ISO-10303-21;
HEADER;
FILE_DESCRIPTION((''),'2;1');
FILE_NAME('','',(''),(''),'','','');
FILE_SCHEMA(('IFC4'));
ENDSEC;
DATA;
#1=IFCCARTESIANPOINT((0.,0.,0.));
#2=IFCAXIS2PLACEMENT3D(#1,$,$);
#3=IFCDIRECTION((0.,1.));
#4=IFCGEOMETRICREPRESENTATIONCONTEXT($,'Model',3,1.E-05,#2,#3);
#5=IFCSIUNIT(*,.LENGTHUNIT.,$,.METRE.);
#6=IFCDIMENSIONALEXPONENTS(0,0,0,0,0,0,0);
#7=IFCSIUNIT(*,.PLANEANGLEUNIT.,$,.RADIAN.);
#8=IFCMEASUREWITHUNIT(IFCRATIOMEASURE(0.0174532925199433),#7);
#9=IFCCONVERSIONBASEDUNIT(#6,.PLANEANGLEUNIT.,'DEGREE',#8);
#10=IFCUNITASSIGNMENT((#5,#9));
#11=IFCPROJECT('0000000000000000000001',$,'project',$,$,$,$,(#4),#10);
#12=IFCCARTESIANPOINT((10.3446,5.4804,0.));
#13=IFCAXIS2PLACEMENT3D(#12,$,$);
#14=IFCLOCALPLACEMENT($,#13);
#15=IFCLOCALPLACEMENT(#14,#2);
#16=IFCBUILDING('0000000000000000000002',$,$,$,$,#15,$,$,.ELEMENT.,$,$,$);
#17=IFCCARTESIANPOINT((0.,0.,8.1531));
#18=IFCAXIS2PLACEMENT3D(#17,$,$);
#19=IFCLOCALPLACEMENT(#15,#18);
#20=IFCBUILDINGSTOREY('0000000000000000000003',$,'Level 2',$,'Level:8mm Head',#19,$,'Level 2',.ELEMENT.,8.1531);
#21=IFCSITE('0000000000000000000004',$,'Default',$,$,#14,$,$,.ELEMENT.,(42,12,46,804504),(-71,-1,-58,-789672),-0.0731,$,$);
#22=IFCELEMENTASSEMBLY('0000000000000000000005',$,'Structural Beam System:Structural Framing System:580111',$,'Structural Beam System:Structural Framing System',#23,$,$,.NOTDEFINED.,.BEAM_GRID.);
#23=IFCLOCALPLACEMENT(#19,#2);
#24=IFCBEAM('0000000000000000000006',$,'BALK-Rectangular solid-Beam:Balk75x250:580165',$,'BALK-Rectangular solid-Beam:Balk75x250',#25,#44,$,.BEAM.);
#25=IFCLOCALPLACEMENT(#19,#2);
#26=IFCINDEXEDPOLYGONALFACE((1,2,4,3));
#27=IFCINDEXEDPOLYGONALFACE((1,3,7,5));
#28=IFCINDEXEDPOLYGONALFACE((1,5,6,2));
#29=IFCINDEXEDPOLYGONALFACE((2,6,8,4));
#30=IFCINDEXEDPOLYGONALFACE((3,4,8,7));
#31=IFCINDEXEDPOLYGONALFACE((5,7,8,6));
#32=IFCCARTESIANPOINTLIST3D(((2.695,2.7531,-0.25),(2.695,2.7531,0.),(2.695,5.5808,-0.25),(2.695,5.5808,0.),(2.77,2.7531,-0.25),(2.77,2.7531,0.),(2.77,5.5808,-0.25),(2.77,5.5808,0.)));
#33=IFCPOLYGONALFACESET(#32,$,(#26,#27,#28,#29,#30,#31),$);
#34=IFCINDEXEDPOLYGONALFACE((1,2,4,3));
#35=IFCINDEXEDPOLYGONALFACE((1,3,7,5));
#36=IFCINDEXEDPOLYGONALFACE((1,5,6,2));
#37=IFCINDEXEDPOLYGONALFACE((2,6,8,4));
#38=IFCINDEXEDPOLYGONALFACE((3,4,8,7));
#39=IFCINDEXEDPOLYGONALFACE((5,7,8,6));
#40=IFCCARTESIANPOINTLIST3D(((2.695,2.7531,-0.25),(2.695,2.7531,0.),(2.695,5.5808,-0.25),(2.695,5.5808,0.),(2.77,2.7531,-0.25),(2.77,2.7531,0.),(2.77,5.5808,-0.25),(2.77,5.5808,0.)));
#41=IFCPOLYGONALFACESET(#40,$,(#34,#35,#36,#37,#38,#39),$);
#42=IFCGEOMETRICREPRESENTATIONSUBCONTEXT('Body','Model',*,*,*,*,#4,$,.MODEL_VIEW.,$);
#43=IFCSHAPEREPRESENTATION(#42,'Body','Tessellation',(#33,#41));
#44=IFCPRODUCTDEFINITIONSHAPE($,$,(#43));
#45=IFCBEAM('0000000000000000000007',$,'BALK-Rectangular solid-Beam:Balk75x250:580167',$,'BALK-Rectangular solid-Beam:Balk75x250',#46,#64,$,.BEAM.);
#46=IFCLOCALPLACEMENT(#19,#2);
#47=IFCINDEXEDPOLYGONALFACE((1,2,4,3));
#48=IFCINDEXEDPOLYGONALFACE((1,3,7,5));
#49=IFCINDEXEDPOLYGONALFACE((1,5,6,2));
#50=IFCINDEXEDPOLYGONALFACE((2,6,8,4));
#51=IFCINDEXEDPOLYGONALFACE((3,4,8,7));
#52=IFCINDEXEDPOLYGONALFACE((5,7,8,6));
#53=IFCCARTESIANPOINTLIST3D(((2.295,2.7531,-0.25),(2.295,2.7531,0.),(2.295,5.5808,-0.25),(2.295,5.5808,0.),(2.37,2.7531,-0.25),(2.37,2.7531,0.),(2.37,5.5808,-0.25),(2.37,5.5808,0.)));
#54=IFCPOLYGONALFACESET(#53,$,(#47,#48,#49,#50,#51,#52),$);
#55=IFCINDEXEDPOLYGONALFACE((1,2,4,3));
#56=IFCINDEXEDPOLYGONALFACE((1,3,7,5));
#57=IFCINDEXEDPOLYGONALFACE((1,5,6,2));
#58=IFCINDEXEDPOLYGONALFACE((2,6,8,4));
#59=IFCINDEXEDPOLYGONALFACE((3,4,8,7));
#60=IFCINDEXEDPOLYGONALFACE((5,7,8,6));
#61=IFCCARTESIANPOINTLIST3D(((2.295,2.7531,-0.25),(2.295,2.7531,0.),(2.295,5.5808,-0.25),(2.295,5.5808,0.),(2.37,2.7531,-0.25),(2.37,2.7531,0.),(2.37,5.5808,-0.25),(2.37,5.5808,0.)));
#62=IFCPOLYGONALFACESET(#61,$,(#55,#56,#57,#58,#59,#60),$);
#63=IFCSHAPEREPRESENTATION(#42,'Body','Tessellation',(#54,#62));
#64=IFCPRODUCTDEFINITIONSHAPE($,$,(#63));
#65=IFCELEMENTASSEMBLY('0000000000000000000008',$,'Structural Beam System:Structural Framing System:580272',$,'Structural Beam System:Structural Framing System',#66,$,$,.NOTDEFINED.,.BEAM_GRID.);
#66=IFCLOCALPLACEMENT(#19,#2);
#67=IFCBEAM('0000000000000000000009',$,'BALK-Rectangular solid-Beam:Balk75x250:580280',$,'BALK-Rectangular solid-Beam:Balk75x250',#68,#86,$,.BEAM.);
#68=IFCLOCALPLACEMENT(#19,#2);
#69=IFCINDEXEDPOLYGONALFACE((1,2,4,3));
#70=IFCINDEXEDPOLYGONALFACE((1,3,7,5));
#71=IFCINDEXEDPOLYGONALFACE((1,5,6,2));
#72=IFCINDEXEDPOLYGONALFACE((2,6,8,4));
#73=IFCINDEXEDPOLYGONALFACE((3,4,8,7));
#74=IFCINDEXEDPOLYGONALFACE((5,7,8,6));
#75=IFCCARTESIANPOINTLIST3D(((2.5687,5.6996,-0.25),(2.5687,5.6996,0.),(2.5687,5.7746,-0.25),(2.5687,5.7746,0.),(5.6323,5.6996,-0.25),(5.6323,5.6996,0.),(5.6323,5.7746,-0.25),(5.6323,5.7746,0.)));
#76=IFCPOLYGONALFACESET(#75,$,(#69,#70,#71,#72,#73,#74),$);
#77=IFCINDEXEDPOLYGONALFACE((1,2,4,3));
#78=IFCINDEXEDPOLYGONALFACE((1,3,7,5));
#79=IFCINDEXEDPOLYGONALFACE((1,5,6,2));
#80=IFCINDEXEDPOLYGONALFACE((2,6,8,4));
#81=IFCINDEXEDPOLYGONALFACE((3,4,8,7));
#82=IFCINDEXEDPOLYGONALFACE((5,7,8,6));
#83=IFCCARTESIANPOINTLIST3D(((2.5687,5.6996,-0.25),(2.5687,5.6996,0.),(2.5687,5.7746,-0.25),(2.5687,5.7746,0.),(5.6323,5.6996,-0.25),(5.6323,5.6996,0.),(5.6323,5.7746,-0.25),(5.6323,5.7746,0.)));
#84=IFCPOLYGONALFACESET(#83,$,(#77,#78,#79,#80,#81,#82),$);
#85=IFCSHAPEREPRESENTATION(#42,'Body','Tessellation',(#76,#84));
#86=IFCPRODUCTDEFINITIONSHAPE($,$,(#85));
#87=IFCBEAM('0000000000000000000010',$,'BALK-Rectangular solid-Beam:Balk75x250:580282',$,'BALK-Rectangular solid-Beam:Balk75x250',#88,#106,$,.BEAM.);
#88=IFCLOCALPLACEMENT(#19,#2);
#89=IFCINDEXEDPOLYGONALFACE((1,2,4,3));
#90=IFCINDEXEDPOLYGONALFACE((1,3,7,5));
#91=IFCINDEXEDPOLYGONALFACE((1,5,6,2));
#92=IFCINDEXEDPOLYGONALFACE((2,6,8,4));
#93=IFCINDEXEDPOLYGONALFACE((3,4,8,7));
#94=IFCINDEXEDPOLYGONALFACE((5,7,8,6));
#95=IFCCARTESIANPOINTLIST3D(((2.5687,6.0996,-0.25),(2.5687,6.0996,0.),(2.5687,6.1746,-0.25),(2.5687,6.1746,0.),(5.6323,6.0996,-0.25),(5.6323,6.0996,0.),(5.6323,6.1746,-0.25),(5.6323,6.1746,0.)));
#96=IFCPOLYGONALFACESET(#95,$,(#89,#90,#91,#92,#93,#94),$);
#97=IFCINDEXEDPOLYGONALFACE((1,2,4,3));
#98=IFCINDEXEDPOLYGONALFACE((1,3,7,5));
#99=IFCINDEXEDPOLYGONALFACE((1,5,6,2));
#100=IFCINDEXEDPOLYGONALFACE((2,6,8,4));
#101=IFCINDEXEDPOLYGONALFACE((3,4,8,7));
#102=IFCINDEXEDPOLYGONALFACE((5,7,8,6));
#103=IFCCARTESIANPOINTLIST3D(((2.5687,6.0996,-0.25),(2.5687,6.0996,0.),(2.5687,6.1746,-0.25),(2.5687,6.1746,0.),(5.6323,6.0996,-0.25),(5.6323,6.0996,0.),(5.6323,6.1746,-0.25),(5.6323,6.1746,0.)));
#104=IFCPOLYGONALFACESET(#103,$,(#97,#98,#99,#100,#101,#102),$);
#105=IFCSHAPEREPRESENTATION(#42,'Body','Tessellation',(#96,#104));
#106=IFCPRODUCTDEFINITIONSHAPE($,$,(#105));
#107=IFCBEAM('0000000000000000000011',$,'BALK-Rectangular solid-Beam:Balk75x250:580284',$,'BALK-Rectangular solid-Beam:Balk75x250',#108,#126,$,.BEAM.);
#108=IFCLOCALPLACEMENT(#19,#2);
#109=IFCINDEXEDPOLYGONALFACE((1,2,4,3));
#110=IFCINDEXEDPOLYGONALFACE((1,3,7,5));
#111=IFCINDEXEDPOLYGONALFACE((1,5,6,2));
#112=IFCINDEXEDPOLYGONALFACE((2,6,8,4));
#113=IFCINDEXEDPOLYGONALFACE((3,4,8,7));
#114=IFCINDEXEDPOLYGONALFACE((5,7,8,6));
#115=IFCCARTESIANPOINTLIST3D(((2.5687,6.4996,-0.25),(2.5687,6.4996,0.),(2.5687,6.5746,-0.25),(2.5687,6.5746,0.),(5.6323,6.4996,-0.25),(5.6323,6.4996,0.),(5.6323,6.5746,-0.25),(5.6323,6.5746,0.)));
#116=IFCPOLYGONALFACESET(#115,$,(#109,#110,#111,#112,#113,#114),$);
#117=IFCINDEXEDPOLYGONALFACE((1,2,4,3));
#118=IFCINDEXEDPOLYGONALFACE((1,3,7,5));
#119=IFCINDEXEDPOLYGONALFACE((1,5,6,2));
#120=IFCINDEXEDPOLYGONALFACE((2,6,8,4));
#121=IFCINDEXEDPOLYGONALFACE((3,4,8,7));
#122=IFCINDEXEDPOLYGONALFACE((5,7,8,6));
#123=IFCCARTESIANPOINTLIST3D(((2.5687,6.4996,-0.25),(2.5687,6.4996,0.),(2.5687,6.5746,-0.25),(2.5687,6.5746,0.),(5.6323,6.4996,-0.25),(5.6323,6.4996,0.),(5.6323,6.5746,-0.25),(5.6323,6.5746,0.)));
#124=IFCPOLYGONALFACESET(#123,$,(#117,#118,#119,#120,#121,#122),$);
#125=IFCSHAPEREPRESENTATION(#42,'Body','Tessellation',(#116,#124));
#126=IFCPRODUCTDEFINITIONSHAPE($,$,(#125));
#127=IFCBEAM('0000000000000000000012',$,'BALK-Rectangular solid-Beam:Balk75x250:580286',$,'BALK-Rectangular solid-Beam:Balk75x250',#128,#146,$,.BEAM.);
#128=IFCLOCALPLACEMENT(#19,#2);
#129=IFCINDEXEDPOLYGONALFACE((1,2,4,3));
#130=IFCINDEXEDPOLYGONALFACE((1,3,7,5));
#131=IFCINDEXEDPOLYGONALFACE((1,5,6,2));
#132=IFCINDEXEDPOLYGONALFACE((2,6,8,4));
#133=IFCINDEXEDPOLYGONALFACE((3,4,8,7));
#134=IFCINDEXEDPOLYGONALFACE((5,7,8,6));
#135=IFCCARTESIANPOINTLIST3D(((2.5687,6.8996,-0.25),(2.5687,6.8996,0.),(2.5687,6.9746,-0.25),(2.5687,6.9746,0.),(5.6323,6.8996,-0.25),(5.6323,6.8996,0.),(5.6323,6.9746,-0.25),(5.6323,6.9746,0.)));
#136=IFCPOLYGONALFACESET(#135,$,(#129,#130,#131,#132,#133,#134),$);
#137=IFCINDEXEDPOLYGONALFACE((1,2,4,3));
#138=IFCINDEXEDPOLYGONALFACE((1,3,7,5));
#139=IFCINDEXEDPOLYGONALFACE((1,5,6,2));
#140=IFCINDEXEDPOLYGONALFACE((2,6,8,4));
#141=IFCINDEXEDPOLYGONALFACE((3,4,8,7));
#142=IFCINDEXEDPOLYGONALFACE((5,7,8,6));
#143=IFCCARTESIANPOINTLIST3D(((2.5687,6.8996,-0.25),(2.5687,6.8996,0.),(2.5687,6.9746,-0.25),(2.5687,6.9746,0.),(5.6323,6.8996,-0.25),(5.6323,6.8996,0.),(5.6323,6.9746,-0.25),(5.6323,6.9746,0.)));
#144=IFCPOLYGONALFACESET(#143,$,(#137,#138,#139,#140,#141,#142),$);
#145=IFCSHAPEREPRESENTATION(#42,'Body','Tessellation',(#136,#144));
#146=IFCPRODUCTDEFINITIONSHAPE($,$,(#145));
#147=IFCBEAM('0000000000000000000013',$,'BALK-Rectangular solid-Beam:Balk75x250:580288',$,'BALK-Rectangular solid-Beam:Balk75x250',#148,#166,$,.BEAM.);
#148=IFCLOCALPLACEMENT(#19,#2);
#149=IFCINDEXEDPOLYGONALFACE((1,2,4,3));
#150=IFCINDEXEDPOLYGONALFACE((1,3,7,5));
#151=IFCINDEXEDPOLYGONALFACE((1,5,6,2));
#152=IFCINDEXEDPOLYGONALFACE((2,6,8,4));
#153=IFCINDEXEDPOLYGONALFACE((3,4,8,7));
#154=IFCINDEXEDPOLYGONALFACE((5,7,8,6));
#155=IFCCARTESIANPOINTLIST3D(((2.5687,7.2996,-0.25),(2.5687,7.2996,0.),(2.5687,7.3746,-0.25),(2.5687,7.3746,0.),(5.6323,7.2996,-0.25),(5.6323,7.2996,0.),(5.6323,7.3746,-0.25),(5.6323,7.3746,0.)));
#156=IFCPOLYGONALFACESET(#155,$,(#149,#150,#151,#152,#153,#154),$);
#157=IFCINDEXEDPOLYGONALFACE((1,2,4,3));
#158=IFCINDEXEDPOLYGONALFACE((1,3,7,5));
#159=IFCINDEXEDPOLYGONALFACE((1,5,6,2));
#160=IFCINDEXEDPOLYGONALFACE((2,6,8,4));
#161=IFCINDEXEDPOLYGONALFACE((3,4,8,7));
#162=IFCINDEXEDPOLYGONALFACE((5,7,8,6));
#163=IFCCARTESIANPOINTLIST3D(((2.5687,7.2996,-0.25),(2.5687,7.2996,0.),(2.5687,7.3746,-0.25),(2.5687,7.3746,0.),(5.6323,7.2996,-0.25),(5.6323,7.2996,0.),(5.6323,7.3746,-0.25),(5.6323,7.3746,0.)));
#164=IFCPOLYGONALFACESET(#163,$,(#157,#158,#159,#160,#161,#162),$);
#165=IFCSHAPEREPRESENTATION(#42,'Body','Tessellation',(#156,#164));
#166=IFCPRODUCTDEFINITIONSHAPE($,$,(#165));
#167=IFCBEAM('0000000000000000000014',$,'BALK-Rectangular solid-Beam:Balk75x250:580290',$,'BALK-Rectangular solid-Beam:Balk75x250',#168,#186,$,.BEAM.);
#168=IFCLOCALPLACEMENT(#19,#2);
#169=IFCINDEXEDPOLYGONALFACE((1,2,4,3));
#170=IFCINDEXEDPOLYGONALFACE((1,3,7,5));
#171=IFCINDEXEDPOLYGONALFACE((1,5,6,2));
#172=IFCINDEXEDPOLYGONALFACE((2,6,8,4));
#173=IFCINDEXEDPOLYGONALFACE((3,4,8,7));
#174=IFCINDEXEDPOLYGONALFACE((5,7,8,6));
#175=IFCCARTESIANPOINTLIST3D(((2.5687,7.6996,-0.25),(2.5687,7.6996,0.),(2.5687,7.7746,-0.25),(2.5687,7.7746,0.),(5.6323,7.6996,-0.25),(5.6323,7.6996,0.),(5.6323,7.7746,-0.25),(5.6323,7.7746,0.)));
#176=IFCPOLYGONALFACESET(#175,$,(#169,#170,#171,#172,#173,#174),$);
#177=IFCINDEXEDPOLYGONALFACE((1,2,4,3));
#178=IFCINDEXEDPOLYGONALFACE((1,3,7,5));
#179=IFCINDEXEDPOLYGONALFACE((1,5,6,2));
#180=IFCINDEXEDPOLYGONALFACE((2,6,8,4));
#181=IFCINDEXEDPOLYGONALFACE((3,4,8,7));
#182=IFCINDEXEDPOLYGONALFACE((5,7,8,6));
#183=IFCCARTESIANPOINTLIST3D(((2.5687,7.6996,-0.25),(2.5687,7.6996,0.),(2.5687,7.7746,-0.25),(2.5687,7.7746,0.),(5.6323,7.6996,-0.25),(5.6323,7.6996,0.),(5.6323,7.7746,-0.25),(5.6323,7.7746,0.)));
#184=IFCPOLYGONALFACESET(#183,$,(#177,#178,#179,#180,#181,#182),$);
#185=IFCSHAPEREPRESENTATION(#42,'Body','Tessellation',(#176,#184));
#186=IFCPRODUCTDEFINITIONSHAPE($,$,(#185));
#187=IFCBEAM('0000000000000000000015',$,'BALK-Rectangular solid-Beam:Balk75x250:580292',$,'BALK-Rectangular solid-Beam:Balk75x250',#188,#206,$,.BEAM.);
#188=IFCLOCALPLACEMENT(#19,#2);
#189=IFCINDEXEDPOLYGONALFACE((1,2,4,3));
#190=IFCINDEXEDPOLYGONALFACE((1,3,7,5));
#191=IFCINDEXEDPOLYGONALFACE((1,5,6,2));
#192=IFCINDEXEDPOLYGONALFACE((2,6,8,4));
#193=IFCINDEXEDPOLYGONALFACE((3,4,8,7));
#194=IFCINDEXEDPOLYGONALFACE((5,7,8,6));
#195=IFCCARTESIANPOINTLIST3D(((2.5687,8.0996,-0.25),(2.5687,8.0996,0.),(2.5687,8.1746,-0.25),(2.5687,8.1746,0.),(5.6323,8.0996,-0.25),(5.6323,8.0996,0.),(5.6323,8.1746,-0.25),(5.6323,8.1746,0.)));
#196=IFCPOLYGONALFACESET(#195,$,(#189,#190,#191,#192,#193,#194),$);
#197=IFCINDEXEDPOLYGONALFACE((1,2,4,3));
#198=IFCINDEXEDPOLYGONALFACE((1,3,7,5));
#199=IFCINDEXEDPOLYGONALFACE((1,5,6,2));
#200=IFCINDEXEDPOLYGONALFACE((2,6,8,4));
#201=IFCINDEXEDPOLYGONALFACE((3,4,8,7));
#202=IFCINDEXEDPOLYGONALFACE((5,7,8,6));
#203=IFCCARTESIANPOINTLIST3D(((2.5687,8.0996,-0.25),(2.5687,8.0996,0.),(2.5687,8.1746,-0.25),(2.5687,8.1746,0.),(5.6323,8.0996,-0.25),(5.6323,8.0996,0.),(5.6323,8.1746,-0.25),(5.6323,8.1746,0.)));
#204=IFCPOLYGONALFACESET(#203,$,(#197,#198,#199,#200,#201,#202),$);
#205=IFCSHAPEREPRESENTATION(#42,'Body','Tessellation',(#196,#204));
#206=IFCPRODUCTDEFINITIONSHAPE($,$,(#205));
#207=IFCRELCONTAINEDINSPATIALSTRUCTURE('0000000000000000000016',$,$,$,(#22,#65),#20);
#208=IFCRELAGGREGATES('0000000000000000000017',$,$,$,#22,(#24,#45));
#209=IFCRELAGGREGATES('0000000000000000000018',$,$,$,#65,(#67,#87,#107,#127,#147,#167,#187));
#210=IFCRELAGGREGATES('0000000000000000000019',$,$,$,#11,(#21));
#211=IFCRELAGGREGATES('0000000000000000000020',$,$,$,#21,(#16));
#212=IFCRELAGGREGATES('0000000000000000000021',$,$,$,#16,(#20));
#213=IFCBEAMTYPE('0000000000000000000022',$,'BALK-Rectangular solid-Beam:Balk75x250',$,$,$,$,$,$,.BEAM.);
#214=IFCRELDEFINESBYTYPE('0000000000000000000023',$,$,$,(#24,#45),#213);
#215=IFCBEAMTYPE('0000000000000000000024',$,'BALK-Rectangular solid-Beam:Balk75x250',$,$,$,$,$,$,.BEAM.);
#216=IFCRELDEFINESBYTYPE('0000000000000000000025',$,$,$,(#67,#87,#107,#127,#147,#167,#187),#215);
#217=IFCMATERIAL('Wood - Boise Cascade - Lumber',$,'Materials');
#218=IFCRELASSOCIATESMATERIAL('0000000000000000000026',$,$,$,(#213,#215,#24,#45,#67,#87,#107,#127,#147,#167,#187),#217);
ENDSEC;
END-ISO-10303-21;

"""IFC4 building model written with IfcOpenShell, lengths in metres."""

from ifc_helpers import new_model, entity, si_unit, converted_unit, direction, frame, frame_2d, origin, origin_2d_with_axis, place, context, subcontext, project, spatial, rectangle, extrude, source, transform, mapped, material, material_profile, profile_set, profile_usage, type_object, type_shapes, element, aggregate, save


model = new_model("IFC4")

# Units and contexts
model_context = context("Model", 3, precision=1e-05, world=origin(), true_north=direction((0.0, 1.0)))
body_context = subcontext(model_context, "Body", "Model", "MODEL_VIEW")
ifc_project = project(units=[si_unit("LENGTHUNIT", "METRE"), converted_unit("PLANEANGLEUNIT", "DEGREE", entity("IfcRatioMeasure", 0.0174532925199433), si_unit("PLANEANGLEUNIT", "RADIAN"), dimensions=[0, 0, 0, 0, 0, 0, 0])], contexts=[model_context])

# Site, building, storey
site_placement = place(None, frame((10.3446, 5.4804, 0.0)))
site = spatial("IfcSite", under=ifc_project, at=site_placement, Name="Default", CompositionType="ELEMENT", RefLatitude=(42, 12, 46, 804504), RefLongitude=(-71, -1, -58, -789672), RefElevation=-0.0731)
building_placement = place(site_placement, origin())
building = spatial("IfcBuilding", under=site, at=building_placement, CompositionType="ELEMENT")
storey_placement = place(building_placement, frame((0.0, 0.0, 8.1531)))
storey = spatial("IfcBuildingStorey", under=building, at=storey_placement, Name="Level 2", ObjectType="Level:8mm Head", LongName="Level 2", CompositionType="ELEMENT", Elevation=8.1531)

# Shared definitions
ifc_material_1 = material(Name="Wood - Boise Cascade - Lumber", Category="Materials")
ifc_material_profile = material_profile(ifc_material_1, rectangle(XDim=0.25, YDim=0.075, at=frame_2d((0.0, 0.0), x_axis=(1.0, 0.0))), Name="Balk75x250")
ifc_profile_set = profile_set([ifc_material_profile], Name="Balk75x250")

# Element assemblies, beams
assembly_1_placement = place(storey_placement, origin())
assembly_1 = element("IfcElementAssembly", 1, at=assembly_1_placement, inside=storey, Name="Structural Beam System:Structural Framing System:580111", ObjectType="Structural Beam System:Structural Framing System", AssemblyPlace="NOTDEFINED", PredefinedType="BEAM_GRID")
beam_type_1 = type_object("IfcBeamType", Name="BALK-Rectangular solid-Beam:Balk75x250", PredefinedType="BEAM", material=ifc_profile_set)
shared_shape_1 = source(origin(), body_context, "Body", "SweptSolid", [
    extrude(rectangle(XDim=0.25, YDim=0.075, at=origin_2d_with_axis()), frame((-1.4138, 0.0, 0.0), z_axis=(1.0, 0.0, 0.0), x_axis=(0.0, 0.0, -1.0)), (0.0, 0.0, 1.0), 2.8276),
    extrude(rectangle(XDim=0.25, YDim=0.075, at=origin_2d_with_axis()), frame((-1.4138, 0.0, 0.0), z_axis=(1.0, 0.0, 0.0), x_axis=(0.0, 0.0, -1.0)), (0.0, 0.0, 1.0), 2.8276),
])
type_shapes(beam_type_1, [shared_shape_1])
ifc_profile_usage_1 = profile_usage(ifc_profile_set, cardinal=8)
beam_1_placement = place(assembly_1_placement, frame((2.7325, 4.167, -0.125), z_axis=(0.0, 0.0, 1.0), x_axis=(0.0, -1.0, 0.0)))
beam_1 = element("IfcBeam", 2, at=beam_1_placement, type_object=beam_type_1, material=ifc_profile_usage_1, Name="BALK-Rectangular solid-Beam:Balk75x250:580165", ObjectType="BALK-Rectangular solid-Beam:Balk75x250", PredefinedType="BEAM", context=body_context, shape_type="MappedRepresentation", body=[
    mapped(shared_shape_1, transform((0.0, 0.0, 0.0), scale=1.0)),
])
ifc_profile_usage_2 = profile_usage(ifc_profile_set, cardinal=8)
beam_2_placement = place(assembly_1_placement, frame((2.3325, 4.167, -0.125), z_axis=(0.0, 0.0, 1.0), x_axis=(0.0, -1.0, 0.0)))
beam_2 = element("IfcBeam", 3, at=beam_2_placement, type_object=beam_type_1, material=ifc_profile_usage_2, Name="BALK-Rectangular solid-Beam:Balk75x250:580167", ObjectType="BALK-Rectangular solid-Beam:Balk75x250", PredefinedType="BEAM", context=body_context, shape_type="MappedRepresentation", body=[
    mapped(shared_shape_1, transform((0.0, 0.0, 0.0), scale=1.0)),
])
aggregate(assembly_1, [beam_1, beam_2])
assembly_2_placement = place(storey_placement, origin())
assembly_2 = element("IfcElementAssembly", 4, at=assembly_2_placement, inside=storey, Name="Structural Beam System:Structural Framing System:580272", ObjectType="Structural Beam System:Structural Framing System", AssemblyPlace="NOTDEFINED", PredefinedType="BEAM_GRID")
ifc_profile_usage_3 = profile_usage(ifc_profile_set, cardinal=8)
beam_type_2 = type_object("IfcBeamType", Name="BALK-Rectangular solid-Beam:Balk75x250", PredefinedType="BEAM", material=ifc_profile_set)
shared_shape_2 = source(origin(), body_context, "Body", "SweptSolid", [
    extrude(rectangle(XDim=0.25, YDim=0.075, at=origin_2d_with_axis()), frame((-1.6506, 0.0, 0.0), z_axis=(1.0, 0.0, 0.0), x_axis=(0.0, 0.0, -1.0)), (0.0, 0.0, 1.0), 3.0636),
    extrude(rectangle(XDim=0.25, YDim=0.075, at=origin_2d_with_axis()), frame((-1.6506, 0.0, 0.0), z_axis=(1.0, 0.0, 0.0), x_axis=(0.0, 0.0, -1.0)), (0.0, 0.0, 1.0), 3.0636),
])
type_shapes(beam_type_2, [shared_shape_2])
beam_3_placement = place(assembly_2_placement, frame((3.9817, 5.7371, -0.125), z_axis=(0.0, 0.0, 1.0), x_axis=(-1.0, 0.0, 0.0)))
beam_3 = element("IfcBeam", 5, at=beam_3_placement, type_object=beam_type_2, material=ifc_profile_usage_3, Name="BALK-Rectangular solid-Beam:Balk75x250:580280", ObjectType="BALK-Rectangular solid-Beam:Balk75x250", PredefinedType="BEAM", context=body_context, shape_type="MappedRepresentation", body=[
    mapped(shared_shape_2, transform((0.0, 0.0, 0.0), scale=1.0)),
])
ifc_profile_usage_4 = profile_usage(ifc_profile_set, cardinal=8)
beam_4_placement = place(assembly_2_placement, frame((3.9817, 6.1371, -0.125), z_axis=(0.0, 0.0, 1.0), x_axis=(-1.0, 0.0, 0.0)))
beam_4 = element("IfcBeam", 6, at=beam_4_placement, type_object=beam_type_2, material=ifc_profile_usage_4, Name="BALK-Rectangular solid-Beam:Balk75x250:580282", ObjectType="BALK-Rectangular solid-Beam:Balk75x250", PredefinedType="BEAM", context=body_context, shape_type="MappedRepresentation", body=[
    mapped(shared_shape_2, transform((0.0, 0.0, 0.0), scale=1.0)),
])
ifc_profile_usage_5 = profile_usage(ifc_profile_set, cardinal=8)
beam_5_placement = place(assembly_2_placement, frame((3.9817, 6.5371, -0.125), z_axis=(0.0, 0.0, 1.0), x_axis=(-1.0, 0.0, 0.0)))
beam_5 = element("IfcBeam", 7, at=beam_5_placement, type_object=beam_type_2, material=ifc_profile_usage_5, Name="BALK-Rectangular solid-Beam:Balk75x250:580284", ObjectType="BALK-Rectangular solid-Beam:Balk75x250", PredefinedType="BEAM", context=body_context, shape_type="MappedRepresentation", body=[
    mapped(shared_shape_2, transform((0.0, 0.0, 0.0), scale=1.0)),
])
ifc_profile_usage_6 = profile_usage(ifc_profile_set, cardinal=8)
beam_6_placement = place(assembly_2_placement, frame((3.9817, 6.9371, -0.125), z_axis=(0.0, 0.0, 1.0), x_axis=(-1.0, 0.0, 0.0)))
beam_6 = element("IfcBeam", 8, at=beam_6_placement, type_object=beam_type_2, material=ifc_profile_usage_6, Name="BALK-Rectangular solid-Beam:Balk75x250:580286", ObjectType="BALK-Rectangular solid-Beam:Balk75x250", PredefinedType="BEAM", context=body_context, shape_type="MappedRepresentation", body=[
    mapped(shared_shape_2, transform((0.0, 0.0, 0.0), scale=1.0)),
])
ifc_profile_usage_7 = profile_usage(ifc_profile_set, cardinal=8)
beam_7_placement = place(assembly_2_placement, frame((3.9817, 7.3371, -0.125), z_axis=(0.0, 0.0, 1.0), x_axis=(-1.0, 0.0, 0.0)))
beam_7 = element("IfcBeam", 9, at=beam_7_placement, type_object=beam_type_2, material=ifc_profile_usage_7, Name="BALK-Rectangular solid-Beam:Balk75x250:580288", ObjectType="BALK-Rectangular solid-Beam:Balk75x250", PredefinedType="BEAM", context=body_context, shape_type="MappedRepresentation", body=[
    mapped(shared_shape_2, transform((0.0, 0.0, 0.0), scale=1.0)),
])
ifc_profile_usage_8 = profile_usage(ifc_profile_set, cardinal=8)
beam_8_placement = place(assembly_2_placement, frame((3.9817, 7.7371, -0.125), z_axis=(0.0, 0.0, 1.0), x_axis=(-1.0, 0.0, 0.0)))
beam_8 = element("IfcBeam", 10, at=beam_8_placement, type_object=beam_type_2, material=ifc_profile_usage_8, Name="BALK-Rectangular solid-Beam:Balk75x250:580290", ObjectType="BALK-Rectangular solid-Beam:Balk75x250", PredefinedType="BEAM", context=body_context, shape_type="MappedRepresentation", body=[
    mapped(shared_shape_2, transform((0.0, 0.0, 0.0), scale=1.0)),
])
ifc_profile_usage_9 = profile_usage(ifc_profile_set, cardinal=8)
beam_9_placement = place(assembly_2_placement, frame((3.9817, 8.1371, -0.125), z_axis=(0.0, 0.0, 1.0), x_axis=(-1.0, 0.0, 0.0)))
beam_9 = element("IfcBeam", 11, at=beam_9_placement, type_object=beam_type_2, material=ifc_profile_usage_9, Name="BALK-Rectangular solid-Beam:Balk75x250:580292", ObjectType="BALK-Rectangular solid-Beam:Balk75x250", PredefinedType="BEAM", context=body_context, shape_type="MappedRepresentation", body=[
    mapped(shared_shape_2, transform((0.0, 0.0, 0.0), scale=1.0)),
])
aggregate(assembly_2, [beam_3, beam_4, beam_5, beam_6, beam_7, beam_8, beam_9])

save(model, "model.ifc")
